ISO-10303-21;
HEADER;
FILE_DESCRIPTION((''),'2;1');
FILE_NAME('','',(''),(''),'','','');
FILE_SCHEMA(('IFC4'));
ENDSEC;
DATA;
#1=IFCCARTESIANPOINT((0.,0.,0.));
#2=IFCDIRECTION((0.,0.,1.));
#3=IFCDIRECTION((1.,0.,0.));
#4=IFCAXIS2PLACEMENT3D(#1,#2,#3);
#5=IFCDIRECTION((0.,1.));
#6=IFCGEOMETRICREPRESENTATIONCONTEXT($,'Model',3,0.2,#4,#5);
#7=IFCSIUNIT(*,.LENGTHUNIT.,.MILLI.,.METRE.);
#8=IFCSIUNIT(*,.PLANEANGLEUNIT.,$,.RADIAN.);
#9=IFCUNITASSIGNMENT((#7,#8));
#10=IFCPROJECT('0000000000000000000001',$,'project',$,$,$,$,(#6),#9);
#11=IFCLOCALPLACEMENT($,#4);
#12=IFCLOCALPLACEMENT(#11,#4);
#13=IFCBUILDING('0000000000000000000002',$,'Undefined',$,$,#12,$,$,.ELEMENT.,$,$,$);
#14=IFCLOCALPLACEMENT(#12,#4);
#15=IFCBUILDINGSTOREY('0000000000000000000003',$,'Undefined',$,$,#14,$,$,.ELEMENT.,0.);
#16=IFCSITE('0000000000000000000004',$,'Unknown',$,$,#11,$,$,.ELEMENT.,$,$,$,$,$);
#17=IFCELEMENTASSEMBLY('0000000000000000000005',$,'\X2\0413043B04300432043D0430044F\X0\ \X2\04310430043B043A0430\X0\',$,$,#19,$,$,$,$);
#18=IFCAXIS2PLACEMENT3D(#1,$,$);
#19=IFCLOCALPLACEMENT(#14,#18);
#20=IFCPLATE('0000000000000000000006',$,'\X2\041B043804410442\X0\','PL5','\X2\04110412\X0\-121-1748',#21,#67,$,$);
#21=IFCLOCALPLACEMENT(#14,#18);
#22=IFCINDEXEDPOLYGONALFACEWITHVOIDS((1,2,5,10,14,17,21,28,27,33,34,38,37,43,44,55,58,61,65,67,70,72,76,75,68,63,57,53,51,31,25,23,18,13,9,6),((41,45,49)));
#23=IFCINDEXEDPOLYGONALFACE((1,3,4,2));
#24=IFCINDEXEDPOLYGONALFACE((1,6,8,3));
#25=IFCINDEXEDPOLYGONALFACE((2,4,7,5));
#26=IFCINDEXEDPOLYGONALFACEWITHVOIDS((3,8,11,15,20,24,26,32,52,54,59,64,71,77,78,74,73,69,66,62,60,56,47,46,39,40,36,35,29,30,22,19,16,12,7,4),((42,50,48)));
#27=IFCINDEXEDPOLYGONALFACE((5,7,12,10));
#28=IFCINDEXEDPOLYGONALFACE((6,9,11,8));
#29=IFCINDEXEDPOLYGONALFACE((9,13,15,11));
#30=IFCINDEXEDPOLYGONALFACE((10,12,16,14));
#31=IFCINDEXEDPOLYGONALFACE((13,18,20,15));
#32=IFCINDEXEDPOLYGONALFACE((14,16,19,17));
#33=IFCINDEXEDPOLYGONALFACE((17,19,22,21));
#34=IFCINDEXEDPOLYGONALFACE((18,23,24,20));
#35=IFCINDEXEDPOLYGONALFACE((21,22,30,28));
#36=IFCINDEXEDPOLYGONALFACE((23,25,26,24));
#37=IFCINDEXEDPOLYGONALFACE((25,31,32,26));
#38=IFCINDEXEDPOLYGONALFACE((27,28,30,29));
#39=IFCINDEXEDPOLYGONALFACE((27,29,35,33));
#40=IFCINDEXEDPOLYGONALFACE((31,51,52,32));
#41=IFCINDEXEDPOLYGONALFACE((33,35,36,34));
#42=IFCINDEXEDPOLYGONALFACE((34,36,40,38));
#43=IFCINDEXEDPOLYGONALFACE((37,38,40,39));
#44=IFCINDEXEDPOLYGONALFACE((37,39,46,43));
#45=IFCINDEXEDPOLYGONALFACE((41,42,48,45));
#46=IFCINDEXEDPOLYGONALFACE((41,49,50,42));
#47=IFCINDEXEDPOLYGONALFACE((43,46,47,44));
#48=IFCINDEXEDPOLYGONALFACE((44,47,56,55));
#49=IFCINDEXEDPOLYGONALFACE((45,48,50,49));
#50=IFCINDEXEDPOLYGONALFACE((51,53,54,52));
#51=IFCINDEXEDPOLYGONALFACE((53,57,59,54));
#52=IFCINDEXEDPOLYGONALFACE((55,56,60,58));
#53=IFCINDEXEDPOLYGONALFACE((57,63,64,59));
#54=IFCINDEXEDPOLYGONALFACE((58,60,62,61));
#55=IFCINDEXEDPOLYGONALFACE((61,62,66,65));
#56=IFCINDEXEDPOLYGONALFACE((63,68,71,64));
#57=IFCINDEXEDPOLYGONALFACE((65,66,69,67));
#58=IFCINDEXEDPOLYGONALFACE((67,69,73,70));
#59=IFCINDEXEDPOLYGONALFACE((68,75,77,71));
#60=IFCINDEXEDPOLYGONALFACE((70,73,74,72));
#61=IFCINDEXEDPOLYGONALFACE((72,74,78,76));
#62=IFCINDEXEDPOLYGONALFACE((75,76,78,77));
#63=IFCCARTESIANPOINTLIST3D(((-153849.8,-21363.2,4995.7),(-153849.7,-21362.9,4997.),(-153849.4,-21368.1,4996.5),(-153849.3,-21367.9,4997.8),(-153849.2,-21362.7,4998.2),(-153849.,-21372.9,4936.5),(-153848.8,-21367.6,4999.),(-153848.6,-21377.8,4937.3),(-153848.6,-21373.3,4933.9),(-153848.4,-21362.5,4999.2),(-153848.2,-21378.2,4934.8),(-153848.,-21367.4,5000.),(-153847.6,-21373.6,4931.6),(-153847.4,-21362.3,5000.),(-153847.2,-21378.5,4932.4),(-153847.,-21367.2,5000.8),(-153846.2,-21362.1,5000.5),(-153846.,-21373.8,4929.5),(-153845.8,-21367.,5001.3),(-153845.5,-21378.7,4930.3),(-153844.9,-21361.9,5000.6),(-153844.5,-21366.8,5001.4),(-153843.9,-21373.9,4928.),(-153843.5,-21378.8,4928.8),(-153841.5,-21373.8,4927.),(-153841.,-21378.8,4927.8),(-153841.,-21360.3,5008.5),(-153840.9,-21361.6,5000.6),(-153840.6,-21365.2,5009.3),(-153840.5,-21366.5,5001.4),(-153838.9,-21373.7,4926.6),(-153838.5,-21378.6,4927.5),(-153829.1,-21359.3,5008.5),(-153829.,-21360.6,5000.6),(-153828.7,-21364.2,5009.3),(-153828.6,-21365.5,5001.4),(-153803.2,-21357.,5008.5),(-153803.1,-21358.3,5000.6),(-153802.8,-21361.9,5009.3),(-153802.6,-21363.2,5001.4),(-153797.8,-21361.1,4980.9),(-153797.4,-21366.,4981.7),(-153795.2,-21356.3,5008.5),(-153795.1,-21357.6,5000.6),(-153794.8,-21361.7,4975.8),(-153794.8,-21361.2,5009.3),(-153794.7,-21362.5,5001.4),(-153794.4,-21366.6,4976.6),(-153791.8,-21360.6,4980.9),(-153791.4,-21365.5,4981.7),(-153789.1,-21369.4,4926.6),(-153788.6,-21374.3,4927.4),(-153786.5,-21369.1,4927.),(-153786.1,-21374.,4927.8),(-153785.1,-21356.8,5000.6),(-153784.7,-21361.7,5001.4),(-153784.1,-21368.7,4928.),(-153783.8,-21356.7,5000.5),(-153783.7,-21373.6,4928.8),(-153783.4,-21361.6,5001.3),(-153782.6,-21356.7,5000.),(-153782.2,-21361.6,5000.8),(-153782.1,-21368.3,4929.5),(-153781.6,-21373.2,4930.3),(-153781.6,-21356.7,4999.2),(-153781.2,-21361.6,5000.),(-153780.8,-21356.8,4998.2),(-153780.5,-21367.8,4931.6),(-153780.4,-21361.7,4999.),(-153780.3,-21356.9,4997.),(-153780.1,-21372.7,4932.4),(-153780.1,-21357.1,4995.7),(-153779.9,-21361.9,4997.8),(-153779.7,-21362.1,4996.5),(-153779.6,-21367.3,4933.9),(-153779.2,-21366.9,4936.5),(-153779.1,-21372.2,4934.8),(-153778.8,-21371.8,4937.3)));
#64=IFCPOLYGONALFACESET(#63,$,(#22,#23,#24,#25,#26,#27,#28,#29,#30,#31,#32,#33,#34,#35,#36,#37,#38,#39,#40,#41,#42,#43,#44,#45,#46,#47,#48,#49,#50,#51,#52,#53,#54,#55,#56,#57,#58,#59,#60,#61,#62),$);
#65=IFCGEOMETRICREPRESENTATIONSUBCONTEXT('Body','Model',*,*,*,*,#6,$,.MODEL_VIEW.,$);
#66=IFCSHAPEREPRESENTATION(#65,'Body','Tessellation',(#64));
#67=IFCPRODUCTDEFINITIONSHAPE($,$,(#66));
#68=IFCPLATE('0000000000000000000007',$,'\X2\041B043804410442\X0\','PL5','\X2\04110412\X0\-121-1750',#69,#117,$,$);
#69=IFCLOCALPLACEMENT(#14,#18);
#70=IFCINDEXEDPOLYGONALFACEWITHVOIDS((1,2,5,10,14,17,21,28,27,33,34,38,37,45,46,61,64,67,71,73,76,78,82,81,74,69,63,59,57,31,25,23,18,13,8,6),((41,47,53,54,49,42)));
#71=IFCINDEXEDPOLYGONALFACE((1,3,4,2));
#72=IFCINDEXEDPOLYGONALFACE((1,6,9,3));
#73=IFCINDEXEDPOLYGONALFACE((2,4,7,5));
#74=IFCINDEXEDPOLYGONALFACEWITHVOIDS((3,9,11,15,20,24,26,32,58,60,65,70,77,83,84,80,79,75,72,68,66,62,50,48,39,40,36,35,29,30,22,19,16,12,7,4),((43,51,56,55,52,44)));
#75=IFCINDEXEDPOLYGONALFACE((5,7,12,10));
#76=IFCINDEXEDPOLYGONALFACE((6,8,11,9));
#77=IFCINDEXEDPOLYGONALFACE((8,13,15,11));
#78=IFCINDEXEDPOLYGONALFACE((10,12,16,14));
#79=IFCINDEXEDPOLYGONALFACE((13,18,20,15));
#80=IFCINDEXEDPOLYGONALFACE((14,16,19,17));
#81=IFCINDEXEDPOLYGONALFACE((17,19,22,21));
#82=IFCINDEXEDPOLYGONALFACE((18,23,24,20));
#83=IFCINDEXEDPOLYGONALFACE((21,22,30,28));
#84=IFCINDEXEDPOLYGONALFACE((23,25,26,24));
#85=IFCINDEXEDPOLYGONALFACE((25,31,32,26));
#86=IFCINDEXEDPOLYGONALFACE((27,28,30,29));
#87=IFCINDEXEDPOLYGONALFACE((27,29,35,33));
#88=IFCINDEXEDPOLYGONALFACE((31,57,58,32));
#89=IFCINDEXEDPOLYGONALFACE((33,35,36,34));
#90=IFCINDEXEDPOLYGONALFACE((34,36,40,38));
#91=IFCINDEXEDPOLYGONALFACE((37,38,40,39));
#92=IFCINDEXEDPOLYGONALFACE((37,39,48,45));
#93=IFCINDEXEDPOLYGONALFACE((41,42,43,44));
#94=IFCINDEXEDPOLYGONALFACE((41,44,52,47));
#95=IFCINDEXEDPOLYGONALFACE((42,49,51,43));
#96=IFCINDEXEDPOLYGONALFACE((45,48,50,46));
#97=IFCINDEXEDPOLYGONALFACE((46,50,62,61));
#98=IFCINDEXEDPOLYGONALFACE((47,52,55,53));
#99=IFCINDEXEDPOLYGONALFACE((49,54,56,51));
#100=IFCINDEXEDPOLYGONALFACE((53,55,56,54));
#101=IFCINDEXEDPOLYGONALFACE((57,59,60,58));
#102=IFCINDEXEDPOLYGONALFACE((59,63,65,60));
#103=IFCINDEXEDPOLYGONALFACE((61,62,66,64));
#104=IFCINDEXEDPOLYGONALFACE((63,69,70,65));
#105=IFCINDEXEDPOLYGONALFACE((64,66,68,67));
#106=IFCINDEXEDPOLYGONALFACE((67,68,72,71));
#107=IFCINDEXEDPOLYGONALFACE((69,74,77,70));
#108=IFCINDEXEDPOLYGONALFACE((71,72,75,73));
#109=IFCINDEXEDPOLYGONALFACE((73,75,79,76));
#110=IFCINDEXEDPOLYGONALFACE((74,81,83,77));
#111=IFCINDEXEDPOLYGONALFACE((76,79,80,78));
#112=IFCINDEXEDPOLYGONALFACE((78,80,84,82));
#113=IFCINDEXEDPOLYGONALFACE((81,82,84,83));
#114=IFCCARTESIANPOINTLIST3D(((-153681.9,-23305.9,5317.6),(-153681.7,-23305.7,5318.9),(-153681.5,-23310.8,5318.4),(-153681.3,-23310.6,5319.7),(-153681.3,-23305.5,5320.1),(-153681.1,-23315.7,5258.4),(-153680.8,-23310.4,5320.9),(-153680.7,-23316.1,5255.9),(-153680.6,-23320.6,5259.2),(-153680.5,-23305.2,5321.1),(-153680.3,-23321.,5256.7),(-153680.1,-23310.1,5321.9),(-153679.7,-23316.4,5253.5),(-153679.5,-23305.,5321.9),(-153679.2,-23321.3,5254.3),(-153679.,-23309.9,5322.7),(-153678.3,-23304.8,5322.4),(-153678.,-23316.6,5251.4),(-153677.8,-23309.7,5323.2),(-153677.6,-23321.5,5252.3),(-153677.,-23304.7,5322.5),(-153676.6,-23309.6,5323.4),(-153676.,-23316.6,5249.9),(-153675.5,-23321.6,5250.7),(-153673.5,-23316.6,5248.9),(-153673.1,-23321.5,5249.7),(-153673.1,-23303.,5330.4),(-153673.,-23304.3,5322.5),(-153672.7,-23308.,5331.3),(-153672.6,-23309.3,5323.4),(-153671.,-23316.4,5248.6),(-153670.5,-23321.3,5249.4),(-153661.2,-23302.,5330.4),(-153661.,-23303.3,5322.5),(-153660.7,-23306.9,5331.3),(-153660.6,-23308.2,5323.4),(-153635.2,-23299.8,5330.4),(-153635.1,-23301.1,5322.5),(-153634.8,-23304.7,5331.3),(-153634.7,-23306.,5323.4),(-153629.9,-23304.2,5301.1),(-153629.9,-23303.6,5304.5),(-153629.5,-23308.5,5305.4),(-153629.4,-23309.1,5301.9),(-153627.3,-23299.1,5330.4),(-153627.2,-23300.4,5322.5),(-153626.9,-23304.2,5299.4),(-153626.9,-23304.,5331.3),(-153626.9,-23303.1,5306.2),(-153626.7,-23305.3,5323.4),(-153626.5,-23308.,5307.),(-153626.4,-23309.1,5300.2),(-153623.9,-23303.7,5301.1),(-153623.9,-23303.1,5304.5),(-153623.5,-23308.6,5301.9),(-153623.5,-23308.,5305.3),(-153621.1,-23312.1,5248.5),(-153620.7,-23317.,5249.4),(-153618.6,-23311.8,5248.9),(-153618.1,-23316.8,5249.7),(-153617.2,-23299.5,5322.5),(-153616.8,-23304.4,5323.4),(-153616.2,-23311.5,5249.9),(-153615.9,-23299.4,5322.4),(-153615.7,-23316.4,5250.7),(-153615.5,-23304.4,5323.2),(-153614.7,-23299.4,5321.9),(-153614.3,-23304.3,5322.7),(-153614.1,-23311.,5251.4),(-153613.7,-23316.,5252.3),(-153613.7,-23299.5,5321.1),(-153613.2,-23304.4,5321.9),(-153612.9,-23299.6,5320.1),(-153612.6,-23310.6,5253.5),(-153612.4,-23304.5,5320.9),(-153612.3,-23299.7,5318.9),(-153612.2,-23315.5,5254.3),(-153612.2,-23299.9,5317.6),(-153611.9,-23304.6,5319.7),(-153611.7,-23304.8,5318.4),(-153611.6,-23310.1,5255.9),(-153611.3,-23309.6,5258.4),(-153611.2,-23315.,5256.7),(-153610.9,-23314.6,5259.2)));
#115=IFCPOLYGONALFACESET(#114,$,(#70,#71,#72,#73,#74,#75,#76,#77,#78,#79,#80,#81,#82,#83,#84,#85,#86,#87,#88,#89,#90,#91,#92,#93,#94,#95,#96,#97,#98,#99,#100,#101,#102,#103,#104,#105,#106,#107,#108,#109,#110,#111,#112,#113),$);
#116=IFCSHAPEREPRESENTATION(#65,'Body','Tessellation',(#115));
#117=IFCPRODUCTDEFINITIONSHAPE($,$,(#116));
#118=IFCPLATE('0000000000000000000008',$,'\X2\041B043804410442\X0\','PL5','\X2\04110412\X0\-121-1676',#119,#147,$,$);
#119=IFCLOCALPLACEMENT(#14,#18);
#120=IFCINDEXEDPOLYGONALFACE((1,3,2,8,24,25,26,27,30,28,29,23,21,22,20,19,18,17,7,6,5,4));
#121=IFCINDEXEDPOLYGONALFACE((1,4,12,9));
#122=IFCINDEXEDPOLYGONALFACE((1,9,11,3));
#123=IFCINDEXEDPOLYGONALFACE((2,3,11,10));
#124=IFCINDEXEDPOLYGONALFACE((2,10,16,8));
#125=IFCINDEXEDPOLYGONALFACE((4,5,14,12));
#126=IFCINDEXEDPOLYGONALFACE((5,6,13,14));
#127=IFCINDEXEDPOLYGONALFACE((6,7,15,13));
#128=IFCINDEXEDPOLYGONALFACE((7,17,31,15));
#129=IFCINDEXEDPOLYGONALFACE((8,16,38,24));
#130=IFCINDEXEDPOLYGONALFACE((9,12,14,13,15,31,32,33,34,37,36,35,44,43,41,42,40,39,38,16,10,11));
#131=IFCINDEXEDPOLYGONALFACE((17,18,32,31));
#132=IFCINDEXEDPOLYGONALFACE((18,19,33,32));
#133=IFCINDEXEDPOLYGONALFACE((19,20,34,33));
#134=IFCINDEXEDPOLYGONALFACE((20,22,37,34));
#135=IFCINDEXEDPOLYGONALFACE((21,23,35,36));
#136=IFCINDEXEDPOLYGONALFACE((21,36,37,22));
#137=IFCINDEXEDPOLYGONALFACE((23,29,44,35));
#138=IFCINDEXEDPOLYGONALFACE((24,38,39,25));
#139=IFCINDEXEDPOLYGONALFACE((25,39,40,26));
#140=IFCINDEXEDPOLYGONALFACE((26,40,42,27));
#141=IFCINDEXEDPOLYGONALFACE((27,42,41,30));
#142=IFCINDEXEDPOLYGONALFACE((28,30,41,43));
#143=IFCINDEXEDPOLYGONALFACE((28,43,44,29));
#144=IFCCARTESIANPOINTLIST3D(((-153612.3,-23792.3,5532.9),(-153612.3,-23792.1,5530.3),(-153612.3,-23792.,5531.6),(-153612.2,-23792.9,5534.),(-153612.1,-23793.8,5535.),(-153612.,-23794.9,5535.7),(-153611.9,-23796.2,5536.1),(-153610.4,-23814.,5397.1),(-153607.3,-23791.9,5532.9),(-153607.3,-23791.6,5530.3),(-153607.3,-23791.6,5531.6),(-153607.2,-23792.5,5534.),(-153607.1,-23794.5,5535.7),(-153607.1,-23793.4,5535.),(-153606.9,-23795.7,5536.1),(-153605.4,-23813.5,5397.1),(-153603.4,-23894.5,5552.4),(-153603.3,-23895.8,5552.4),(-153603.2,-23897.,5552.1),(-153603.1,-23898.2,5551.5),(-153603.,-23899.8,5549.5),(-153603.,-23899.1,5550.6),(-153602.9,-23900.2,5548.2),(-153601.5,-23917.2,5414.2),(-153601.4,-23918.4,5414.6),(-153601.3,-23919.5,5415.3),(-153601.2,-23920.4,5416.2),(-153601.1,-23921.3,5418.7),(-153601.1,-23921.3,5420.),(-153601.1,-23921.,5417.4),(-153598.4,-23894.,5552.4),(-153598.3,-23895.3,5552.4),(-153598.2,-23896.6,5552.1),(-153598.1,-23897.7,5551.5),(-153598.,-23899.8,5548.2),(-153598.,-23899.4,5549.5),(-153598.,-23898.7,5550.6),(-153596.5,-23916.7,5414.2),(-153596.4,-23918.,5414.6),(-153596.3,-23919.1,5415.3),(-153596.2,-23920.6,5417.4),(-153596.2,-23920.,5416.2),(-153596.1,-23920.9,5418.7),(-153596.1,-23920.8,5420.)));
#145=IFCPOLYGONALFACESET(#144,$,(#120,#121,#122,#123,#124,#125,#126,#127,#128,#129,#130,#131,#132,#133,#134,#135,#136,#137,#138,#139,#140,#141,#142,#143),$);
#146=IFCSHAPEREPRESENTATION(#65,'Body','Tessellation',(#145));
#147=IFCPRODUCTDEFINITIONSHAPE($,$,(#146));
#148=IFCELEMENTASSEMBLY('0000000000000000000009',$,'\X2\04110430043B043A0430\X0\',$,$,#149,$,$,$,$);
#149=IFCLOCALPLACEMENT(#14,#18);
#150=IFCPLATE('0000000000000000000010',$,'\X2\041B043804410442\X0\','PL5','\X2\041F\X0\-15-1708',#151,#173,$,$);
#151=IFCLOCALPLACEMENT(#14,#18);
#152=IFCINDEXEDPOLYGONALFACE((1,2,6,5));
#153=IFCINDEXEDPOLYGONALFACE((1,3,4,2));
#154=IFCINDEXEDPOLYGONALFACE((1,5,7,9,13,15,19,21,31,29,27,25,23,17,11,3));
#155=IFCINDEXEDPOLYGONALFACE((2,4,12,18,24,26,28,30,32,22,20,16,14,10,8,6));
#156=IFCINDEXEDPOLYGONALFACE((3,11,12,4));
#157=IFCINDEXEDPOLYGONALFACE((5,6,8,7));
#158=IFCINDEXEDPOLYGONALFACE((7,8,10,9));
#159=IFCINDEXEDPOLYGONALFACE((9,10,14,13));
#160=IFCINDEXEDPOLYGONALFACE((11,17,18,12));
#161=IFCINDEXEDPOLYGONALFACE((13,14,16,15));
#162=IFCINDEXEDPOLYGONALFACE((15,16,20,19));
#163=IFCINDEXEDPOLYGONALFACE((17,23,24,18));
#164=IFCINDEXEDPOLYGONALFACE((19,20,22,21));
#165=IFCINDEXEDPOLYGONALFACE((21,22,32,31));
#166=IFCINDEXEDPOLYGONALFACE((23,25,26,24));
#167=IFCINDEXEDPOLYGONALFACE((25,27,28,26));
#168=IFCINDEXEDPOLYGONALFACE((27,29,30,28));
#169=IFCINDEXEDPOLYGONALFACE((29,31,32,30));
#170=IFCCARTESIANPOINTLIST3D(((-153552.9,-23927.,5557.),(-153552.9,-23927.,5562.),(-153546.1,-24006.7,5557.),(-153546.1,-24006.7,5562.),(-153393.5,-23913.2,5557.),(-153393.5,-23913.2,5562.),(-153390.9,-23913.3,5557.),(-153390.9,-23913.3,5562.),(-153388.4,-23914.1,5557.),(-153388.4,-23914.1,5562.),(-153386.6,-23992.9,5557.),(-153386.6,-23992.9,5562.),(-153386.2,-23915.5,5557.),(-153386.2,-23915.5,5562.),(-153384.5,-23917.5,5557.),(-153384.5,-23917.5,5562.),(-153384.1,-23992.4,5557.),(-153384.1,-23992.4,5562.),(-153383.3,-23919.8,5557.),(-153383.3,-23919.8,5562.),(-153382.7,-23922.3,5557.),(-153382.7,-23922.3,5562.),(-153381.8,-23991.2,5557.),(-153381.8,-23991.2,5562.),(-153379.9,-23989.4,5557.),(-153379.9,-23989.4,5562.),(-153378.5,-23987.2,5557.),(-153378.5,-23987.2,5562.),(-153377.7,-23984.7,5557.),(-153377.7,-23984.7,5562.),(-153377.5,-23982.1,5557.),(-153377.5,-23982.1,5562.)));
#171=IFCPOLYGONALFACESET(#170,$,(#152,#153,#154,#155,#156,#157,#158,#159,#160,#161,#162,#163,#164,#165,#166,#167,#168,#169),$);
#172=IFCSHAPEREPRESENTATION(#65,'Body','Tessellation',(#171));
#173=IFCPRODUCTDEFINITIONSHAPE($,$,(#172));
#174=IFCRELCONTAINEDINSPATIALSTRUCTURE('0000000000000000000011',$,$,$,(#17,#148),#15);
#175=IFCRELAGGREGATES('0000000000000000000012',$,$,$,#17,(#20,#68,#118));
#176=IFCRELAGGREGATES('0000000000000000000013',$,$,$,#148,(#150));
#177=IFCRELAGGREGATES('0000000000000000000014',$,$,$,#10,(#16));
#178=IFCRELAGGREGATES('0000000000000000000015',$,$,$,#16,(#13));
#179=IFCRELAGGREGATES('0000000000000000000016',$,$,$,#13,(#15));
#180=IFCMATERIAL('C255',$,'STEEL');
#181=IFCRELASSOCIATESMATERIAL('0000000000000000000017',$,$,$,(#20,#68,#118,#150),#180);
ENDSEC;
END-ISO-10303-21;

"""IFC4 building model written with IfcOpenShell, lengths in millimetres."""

from ifc_helpers import new_model, si_unit, direction, frame, origin_with_axes, place, context, subcontext, project, spatial, line, arc, indexed_curve, outline, extrude, material, element, aggregate, save


model = new_model("IFC4")

# Units and contexts
model_context = context("Model", 3, precision=0.2, world=origin_with_axes(), true_north=direction((0.0, 1.0)))
body_context = subcontext(model_context, "Body", "Model", "MODEL_VIEW")
ifc_project = project(units=[si_unit("LENGTHUNIT", "METRE", prefix="MILLI"), si_unit("PLANEANGLEUNIT", "RADIAN")], contexts=[model_context])

# Site, building, storey
site_placement = place(None, origin_with_axes())
site = spatial("IfcSite", under=ifc_project, at=site_placement, Name="Unknown", CompositionType="ELEMENT")
building_placement = place(site_placement, origin_with_axes())
building = spatial("IfcBuilding", under=site, at=building_placement, Name="Undefined", CompositionType="ELEMENT")
storey_placement = place(building_placement, origin_with_axes())
storey = spatial("IfcBuildingStorey", under=building, at=storey_placement, Name="Undefined", CompositionType="ELEMENT", Elevation=0.0)

# Shared definitions
ifc_material_1 = material(Name="C255", Category="STEEL")

# Element assembly, plates, voiding features
assembly_1_placement = place(storey_placement, frame((-153842.1, -21103.9, 5019.0), z_axis=(-0.996285, -0.086114, 0.000024), x_axis=(0.084961, -0.982981, 0.162881)))
assembly_1 = element("IfcElementAssembly", 1, at=assembly_1_placement, inside=storey, Name="Главная балка")
plate_1_placement = place(assembly_1_placement, frame((252.9, -135.0, -40.0), z_axis=(-1.0, -0.000054, 0.0), x_axis=(0.0, 0.000054, 1.0)))
plate_1 = element("IfcPlate", 2, at=plate_1_placement, material=ifc_material_1, Name="Лист", Description="PL5", ObjectType="БВ-121-1748", context=body_context, shape_type="SolidModel", body=[
    extrude(outline(indexed_curve([(0.0, 10.0), (2.9, 2.9), (10.0, 0.0), (60.0, 0.0), (67.1, 2.9), (70.0, 10.0), (70.0, 70.0), (68.5, 73.5), (65.0, 75.0), (61.0, 75.0), (61.0, 83.0), (49.0, 83.0), (49.0, 75.0), (23.0, 75.0), (23.0, 83.0), (15.0, 83.0), (15.0, 75.0), (5.0, 75.0), (1.5, 73.5), (0.0, 70.0)], segments=[arc(1, 2, 3), line(3, 4), arc(4, 5, 6), line(6, 7), arc(7, 8, 9), line(9, 10, 11, 12, 13, 14, 15, 16, 17, 18), arc(18, 19, 20), line(20, 1)])), frame((0.0, 0.0, 2.5), z_axis=(0.0, 0.0, 1.0), x_axis=(1.0, 0.0, 0.0)), (0.0, 0.0, -1.0), 5.0),
])
voiding_feature_1_placement = place(plate_1_placement, frame((15.0, 55.0, 10.0), z_axis=(0.007997, -0.999968, -0.000026), x_axis=(0.0, 0.000026, -1.0)))
element("IfcVoidingFeature", 3, at=voiding_feature_1_placement, cuts=plate_1, Name="Балка", ObjectType="(?)", PredefinedType="HOLE", context=body_context, shape_type="SolidModel", body=[
    extrude(outline(indexed_curve([(0.0, -3.0), (5.2, 0.0), (0.0, 3.0)], segments=[line(1, 2, 3, 1)])), frame((0.0, 0.0, 0.0), z_axis=(-1.0, 0.0, 0.0), x_axis=(0.0, 0.0, 1.0)), (0.0, 0.0, -1.0), 20.0),
])
plate_2_placement = place(assembly_1_placement, frame((2229.3, -135.0, -40.0), z_axis=(-1.0, -0.000054, 0.0), x_axis=(0.0, 0.000054, 1.0)))
plate_2 = element("IfcPlate", 4, at=plate_2_placement, material=ifc_material_1, Name="Лист", Description="PL5", ObjectType="БВ-121-1750", context=body_context, shape_type="SolidModel", body=[
    extrude(outline(indexed_curve([(0.0, 10.0), (2.9, 2.9), (10.0, 0.0), (60.0, 0.0), (67.1, 2.9), (70.0, 10.0), (70.0, 70.0), (68.5, 73.5), (65.0, 75.0), (61.0, 75.0), (61.0, 83.0), (49.0, 83.0), (49.0, 75.0), (23.0, 75.0), (23.0, 83.0), (15.0, 83.0), (15.0, 75.0), (5.0, 75.0), (1.5, 73.5), (0.0, 70.0)], segments=[arc(1, 2, 3), line(3, 4), arc(4, 5, 6), line(6, 7), arc(7, 8, 9), line(9, 10, 11, 12, 13, 14, 15, 16, 17, 18), arc(18, 19, 20), line(20, 1)])), frame((0.0, 0.0, 2.5), z_axis=(0.0, 0.0, 1.0), x_axis=(1.0, 0.0, 0.0)), (0.0, 0.0, -1.0), 5.0),
])
voiding_feature_2_placement = place(plate_2_placement, frame((15.0, 55.0, 10.0), z_axis=(0.007997, -0.999968, -0.000026), x_axis=(0.0, 0.000026, -1.0)))
element("IfcVoidingFeature", 5, at=voiding_feature_2_placement, cuts=plate_2, Name="Балка", ObjectType="(?)", PredefinedType="HOLE", context=body_context, shape_type="SolidModel", body=[
    extrude(outline(indexed_curve([(1.7, -3.0), (3.5, 0.0), (1.7, 3.0), (-1.7, 3.0), (-3.5, 0.0), (-1.7, -3.0)], segments=[line(1, 2, 3, 4, 5, 6, 1)])), frame((0.0, 0.0, 0.0), z_axis=(-1.0, 0.0, 0.0), x_axis=(0.0, 0.0, 1.0)), (0.0, 0.0, -1.0), 20.0),
])
plate_3_placement = place(assembly_1_placement, frame((2855.2, 70.0, 0.0), z_axis=(0.0, 0.0, -1.0), x_axis=(0.0, -1.0, 0.0)))
plate_3 = element("IfcPlate", 6, at=plate_3_placement, material=ifc_material_1, Name="Лист", Description="PL5", ObjectType="БВ-121-1676", context=body_context, shape_type="SolidModel", body=[
    extrude(outline(indexed_curve([(0.0, 5.0), (1.5, 1.5), (5.0, 0.0), (135.0, 0.0), (138.5, 1.5), (140.0, 5.0), (140.0, 110.0), (5.0, 110.0), (1.5, 108.5), (0.0, 105.0)], segments=[arc(1, 2, 3), line(3, 4), arc(4, 5, 6), line(6, 7, 8), arc(8, 9, 10), line(10, 1)])), frame((0.0, 0.0, 2.5), z_axis=(0.0, 0.0, 1.0), x_axis=(1.0, 0.0, 0.0)), (0.0, 0.0, -1.0), 5.0),
])
aggregate(assembly_1, [plate_1, plate_2, plate_3])

# Element assembly, plate
assembly_2_placement = place(storey_placement, frame((-153552.0, -23967.1, 5606.0), z_axis=(0.996285, 0.086114, 0.0), x_axis=(0.0, 0.0, -1.0)))
assembly_2 = element("IfcElementAssembly", 7, at=assembly_2_placement, inside=storey, Name="Балка")
plate_4_placement = place(assembly_2_placement, frame((46.5, 40.0, 2.5), z_axis=(-1.0, 0.0, 0.0), x_axis=(0.0, -1.0, 0.0)))
plate_4 = element("IfcPlate", 8, at=plate_4_placement, material=ifc_material_1, Name="Лист", Description="PL5", ObjectType="П-15-1708", context=body_context, shape_type="SolidModel", body=[
    extrude(outline(indexed_curve([(0.0, 0.0), (80.0, 0.0), (80.0, 160.0), (77.1, 167.1), (70.0, 170.0), (10.0, 170.0), (2.9, 167.1), (0.0, 160.0)], segments=[line(1, 2, 3), arc(3, 4, 5), line(5, 6), arc(6, 7, 8), line(8, 1)])), frame((0.0, 0.0, 2.5), z_axis=(0.0, 0.0, 1.0), x_axis=(1.0, 0.0, 0.0)), (0.0, 0.0, -1.0), 5.0),
])

aggregate(assembly_2, [plate_4])

save(model, "model.ifc")
